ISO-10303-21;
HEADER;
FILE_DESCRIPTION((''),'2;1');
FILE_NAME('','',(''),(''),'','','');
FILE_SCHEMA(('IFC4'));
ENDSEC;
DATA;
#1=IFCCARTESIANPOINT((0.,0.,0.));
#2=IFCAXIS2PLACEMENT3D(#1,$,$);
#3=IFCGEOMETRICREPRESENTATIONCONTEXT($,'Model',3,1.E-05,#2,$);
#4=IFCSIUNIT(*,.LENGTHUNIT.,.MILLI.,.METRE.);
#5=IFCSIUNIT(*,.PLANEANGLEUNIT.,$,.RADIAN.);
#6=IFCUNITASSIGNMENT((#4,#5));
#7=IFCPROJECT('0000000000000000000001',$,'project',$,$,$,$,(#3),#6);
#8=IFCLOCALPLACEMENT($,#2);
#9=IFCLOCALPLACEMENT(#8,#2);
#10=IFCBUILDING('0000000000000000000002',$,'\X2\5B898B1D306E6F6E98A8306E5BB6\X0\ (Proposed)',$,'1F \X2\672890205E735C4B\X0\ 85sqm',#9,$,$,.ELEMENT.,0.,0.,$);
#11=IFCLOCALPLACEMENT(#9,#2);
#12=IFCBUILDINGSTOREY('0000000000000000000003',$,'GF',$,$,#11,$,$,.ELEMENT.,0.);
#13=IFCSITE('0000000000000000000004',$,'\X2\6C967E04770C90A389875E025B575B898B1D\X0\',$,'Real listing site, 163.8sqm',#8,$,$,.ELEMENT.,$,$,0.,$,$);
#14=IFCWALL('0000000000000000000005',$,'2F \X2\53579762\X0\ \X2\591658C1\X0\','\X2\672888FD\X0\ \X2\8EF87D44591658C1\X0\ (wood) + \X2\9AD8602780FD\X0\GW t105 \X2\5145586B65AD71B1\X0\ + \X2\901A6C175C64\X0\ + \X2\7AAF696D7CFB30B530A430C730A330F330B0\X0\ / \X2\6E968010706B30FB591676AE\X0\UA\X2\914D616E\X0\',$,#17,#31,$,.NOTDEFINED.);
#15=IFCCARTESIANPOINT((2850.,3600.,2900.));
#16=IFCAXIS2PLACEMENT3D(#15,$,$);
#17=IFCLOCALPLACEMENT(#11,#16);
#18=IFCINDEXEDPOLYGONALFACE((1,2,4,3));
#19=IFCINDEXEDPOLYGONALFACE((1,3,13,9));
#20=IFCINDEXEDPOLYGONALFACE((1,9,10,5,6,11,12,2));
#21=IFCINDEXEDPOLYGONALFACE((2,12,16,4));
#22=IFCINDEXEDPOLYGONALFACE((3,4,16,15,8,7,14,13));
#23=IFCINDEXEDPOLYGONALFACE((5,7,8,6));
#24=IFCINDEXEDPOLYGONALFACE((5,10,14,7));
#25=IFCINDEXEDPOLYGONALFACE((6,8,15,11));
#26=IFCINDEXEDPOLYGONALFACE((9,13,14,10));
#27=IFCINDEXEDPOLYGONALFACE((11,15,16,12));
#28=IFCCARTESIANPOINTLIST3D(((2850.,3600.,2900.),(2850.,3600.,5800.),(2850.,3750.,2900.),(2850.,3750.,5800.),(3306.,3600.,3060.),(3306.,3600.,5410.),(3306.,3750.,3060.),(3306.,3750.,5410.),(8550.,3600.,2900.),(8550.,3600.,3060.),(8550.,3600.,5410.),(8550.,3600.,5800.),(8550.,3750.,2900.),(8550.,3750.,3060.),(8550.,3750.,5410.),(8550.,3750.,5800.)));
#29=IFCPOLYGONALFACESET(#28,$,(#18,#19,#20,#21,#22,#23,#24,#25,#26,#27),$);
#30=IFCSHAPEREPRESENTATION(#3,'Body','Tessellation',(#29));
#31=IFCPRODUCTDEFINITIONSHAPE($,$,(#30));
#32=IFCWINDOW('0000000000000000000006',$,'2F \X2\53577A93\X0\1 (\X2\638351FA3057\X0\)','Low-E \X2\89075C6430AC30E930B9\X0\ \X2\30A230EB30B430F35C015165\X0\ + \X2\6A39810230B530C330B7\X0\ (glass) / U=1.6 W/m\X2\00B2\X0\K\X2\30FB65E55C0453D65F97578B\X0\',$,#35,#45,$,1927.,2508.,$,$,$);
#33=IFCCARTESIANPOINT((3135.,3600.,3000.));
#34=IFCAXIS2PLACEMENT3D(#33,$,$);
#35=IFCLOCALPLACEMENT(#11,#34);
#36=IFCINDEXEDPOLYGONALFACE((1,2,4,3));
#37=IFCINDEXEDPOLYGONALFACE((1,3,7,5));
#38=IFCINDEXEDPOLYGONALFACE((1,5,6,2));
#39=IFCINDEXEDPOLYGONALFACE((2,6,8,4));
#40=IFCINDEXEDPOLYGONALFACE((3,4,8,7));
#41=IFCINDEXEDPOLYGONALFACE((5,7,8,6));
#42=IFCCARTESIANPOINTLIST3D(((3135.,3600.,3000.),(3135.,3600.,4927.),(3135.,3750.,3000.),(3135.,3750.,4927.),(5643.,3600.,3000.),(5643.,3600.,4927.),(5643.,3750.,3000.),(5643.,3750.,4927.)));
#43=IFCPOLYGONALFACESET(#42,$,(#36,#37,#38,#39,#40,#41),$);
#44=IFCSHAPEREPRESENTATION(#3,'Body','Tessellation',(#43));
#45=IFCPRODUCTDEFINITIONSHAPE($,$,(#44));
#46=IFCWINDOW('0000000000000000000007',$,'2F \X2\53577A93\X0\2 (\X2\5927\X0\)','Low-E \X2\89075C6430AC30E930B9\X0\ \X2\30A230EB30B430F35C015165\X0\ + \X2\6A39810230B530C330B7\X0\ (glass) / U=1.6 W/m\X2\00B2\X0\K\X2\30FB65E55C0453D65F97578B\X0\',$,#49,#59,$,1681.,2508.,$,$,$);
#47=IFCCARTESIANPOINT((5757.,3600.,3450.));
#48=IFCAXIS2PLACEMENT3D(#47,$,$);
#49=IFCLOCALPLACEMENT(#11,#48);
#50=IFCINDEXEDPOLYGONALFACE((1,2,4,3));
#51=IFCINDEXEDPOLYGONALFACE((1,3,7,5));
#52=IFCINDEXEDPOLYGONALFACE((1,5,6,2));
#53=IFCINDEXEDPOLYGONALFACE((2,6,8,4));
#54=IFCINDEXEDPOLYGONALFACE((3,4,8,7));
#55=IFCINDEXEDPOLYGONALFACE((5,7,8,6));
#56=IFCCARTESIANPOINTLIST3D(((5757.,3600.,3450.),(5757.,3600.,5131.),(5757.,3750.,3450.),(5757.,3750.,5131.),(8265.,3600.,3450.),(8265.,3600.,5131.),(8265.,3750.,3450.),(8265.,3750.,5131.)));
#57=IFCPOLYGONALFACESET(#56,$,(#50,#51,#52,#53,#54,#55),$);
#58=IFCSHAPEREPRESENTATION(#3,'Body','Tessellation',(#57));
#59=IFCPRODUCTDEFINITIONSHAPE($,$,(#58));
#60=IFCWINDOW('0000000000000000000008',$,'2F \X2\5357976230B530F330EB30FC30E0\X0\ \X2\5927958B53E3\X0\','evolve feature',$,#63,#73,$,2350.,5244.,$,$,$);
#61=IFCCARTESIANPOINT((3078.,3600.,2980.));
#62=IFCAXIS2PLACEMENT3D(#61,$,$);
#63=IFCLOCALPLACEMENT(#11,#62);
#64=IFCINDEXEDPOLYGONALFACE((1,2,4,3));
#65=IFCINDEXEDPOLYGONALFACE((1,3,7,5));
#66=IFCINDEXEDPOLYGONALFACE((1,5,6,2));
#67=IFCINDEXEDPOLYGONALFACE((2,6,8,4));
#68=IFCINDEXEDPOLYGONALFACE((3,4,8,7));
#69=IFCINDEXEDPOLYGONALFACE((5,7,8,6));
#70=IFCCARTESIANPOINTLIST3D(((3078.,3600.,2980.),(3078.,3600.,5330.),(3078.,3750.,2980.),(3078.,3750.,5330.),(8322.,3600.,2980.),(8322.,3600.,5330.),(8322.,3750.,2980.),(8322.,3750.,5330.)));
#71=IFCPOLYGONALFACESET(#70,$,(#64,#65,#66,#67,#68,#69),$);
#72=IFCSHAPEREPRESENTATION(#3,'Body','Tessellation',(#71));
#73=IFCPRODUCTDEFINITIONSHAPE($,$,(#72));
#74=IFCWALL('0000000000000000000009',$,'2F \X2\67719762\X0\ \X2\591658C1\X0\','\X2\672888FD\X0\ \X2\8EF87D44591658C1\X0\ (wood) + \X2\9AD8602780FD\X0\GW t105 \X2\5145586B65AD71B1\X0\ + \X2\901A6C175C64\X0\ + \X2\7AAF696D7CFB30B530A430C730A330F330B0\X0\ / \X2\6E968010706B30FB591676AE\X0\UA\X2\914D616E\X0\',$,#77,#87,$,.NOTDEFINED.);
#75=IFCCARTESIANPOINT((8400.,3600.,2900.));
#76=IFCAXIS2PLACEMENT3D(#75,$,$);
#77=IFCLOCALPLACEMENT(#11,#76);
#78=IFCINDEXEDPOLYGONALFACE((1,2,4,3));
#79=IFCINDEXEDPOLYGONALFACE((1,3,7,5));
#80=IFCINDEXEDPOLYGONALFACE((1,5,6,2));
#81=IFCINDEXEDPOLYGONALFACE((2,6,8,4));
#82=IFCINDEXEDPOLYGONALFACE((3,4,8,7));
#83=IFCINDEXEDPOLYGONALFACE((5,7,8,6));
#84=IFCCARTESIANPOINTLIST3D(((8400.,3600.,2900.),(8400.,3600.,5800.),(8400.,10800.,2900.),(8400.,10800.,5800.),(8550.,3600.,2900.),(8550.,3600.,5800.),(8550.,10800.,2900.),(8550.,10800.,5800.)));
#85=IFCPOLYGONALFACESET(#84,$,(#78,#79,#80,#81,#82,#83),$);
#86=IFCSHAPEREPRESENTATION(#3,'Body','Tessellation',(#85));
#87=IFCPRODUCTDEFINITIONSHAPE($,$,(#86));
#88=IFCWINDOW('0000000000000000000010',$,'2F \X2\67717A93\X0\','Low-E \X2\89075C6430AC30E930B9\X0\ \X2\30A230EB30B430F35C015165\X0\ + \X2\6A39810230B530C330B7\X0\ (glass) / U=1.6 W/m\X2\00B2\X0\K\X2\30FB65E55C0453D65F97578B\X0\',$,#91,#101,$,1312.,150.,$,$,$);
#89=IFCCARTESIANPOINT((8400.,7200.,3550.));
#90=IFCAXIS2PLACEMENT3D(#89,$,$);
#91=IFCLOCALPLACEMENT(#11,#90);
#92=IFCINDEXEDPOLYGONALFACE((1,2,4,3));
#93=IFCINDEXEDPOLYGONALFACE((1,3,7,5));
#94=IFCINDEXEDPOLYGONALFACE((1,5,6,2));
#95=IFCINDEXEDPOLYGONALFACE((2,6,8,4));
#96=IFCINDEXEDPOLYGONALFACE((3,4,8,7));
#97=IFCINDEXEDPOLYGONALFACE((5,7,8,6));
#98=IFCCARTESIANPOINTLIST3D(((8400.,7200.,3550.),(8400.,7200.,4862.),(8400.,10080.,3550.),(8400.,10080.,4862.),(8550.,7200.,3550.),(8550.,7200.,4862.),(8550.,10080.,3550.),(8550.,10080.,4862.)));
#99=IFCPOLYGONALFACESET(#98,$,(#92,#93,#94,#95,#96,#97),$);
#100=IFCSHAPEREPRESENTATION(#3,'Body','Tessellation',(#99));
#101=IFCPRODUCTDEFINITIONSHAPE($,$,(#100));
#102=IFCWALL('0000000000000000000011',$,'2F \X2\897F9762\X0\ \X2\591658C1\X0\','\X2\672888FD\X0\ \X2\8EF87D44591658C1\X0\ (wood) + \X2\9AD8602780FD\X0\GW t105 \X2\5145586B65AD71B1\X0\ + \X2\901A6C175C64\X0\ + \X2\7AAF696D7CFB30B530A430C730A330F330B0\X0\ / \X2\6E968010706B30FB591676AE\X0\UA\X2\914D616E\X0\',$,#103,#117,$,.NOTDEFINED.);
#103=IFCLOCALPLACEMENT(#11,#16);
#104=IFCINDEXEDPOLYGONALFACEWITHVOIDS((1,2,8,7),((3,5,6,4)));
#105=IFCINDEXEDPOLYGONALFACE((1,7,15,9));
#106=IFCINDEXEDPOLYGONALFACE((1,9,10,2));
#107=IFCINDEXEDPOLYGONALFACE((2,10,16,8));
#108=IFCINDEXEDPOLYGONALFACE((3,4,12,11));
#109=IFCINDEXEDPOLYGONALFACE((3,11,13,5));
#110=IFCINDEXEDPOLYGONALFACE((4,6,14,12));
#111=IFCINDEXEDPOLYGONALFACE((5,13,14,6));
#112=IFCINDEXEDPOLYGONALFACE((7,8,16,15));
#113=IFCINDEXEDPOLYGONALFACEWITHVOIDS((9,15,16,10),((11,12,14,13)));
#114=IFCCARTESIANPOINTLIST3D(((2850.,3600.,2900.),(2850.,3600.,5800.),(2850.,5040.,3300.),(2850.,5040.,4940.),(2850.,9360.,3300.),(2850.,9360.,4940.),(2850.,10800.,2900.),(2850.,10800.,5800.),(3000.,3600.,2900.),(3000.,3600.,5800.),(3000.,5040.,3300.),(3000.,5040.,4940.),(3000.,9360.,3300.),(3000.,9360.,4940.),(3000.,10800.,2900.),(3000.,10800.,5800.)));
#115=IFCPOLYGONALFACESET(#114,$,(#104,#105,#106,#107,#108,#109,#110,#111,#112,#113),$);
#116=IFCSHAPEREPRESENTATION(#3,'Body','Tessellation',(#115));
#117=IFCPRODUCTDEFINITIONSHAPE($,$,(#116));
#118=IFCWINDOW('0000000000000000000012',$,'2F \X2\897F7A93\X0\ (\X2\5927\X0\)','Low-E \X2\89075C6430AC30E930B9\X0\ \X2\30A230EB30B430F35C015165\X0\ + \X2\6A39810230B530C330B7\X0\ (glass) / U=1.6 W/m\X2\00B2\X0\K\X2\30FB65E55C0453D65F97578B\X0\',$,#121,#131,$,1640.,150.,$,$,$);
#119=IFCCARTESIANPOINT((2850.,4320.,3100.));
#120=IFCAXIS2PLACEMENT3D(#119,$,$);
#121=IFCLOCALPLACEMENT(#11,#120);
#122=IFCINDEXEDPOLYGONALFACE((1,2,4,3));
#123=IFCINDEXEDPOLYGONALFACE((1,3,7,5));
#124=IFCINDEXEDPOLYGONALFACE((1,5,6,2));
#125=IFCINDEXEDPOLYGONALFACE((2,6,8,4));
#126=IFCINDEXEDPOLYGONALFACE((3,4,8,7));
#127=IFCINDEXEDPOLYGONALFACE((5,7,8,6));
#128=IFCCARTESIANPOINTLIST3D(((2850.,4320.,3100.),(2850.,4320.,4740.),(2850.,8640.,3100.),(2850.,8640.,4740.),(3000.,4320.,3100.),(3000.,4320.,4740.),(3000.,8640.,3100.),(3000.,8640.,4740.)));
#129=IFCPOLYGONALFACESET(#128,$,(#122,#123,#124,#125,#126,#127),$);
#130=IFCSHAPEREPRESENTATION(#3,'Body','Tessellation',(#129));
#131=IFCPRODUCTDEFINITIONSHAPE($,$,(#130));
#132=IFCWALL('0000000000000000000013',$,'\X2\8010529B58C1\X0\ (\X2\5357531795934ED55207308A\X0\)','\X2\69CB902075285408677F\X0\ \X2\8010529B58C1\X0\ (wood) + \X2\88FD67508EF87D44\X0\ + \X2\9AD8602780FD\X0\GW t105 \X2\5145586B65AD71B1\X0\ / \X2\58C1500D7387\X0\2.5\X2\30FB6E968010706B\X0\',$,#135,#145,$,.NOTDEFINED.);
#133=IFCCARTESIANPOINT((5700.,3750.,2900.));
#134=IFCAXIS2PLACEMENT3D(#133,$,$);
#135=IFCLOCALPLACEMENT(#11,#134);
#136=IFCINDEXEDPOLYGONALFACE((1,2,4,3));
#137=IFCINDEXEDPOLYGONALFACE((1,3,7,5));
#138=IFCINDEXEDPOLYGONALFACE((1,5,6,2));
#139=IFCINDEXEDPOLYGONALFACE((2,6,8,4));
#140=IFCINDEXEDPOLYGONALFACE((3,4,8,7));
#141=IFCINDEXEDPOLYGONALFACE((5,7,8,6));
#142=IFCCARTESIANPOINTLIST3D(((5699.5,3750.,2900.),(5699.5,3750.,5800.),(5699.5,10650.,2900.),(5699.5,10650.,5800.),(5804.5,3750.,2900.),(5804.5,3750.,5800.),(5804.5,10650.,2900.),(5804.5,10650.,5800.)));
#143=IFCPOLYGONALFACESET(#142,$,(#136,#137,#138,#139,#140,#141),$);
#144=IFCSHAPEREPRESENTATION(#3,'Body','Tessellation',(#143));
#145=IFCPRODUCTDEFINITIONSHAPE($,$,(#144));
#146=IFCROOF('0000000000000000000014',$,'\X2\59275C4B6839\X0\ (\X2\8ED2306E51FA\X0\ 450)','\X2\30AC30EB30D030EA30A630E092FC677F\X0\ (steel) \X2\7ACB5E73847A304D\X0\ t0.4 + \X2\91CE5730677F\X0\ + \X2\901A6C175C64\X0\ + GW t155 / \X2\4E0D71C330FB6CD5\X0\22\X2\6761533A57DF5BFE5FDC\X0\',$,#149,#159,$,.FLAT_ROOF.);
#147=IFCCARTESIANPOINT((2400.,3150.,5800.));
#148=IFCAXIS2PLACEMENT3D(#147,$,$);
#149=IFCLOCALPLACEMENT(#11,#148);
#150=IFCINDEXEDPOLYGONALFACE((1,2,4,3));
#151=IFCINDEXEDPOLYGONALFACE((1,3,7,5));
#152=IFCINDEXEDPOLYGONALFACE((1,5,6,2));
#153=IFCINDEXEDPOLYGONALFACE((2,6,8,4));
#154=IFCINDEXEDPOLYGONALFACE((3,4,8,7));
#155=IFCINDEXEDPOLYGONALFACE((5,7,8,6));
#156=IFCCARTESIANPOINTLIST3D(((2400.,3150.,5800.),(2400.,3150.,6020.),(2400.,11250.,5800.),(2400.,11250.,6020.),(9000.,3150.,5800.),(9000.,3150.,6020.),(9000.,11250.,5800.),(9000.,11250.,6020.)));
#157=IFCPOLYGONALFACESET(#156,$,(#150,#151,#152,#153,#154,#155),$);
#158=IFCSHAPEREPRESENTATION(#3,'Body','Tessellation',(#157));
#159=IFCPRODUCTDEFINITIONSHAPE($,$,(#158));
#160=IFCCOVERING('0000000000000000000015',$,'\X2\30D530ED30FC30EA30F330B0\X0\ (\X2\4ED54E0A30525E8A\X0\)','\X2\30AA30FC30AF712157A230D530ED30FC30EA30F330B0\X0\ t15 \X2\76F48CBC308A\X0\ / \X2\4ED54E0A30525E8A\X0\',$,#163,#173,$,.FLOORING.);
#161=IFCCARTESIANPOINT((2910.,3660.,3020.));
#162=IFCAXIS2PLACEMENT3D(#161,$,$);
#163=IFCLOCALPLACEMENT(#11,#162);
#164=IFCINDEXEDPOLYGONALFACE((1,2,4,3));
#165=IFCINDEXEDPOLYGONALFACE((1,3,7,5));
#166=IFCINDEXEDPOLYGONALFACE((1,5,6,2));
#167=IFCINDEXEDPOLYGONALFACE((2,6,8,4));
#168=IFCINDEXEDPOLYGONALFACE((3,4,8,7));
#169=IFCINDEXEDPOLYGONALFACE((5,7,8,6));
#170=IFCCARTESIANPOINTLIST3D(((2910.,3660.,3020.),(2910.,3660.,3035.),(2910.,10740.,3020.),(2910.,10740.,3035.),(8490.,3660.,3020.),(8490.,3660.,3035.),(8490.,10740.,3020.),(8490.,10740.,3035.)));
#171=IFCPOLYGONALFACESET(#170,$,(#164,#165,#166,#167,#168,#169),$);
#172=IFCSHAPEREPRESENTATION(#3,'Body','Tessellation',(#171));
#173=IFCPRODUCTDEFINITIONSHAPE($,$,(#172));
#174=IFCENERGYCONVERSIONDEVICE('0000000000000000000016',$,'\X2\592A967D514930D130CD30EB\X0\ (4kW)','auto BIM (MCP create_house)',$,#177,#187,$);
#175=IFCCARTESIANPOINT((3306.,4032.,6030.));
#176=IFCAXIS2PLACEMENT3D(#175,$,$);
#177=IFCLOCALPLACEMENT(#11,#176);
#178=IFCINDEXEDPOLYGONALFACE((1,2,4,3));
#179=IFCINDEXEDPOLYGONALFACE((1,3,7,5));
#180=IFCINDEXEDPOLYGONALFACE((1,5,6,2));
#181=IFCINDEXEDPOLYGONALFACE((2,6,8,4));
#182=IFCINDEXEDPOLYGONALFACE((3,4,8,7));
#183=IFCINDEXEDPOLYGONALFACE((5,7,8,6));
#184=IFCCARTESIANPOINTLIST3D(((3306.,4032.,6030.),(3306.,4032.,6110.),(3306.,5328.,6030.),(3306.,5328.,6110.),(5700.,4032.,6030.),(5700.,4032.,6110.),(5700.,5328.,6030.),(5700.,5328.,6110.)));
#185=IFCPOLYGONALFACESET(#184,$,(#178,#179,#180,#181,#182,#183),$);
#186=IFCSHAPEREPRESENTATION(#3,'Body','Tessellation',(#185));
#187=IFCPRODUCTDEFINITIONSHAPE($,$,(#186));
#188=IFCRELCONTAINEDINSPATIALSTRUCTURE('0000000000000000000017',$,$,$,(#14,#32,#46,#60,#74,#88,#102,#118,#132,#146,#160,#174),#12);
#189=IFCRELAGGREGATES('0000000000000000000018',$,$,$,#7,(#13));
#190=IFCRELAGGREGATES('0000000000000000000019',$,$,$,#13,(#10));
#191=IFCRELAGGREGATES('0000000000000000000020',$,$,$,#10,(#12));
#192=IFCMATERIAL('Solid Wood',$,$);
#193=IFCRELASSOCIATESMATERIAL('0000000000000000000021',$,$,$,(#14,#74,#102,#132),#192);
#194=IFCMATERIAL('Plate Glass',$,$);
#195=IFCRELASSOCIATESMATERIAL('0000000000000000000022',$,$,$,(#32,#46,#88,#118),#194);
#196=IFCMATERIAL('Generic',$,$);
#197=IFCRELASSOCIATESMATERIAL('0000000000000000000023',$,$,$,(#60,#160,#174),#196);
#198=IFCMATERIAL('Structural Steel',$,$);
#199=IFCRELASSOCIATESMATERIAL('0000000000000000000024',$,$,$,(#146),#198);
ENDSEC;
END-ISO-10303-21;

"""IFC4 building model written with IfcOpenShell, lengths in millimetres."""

from ifc_helpers import new_model, si_unit, frame, frame_2d, origin, place, context, project, spatial, rectangle, extrude, material, element, fill, save


model = new_model("IFC4")

# Units and contexts
model_context = context("Model", 3, precision=1e-05, world=origin())
ifc_project = project(units=[si_unit("LENGTHUNIT", "METRE", prefix="MILLI"), si_unit("PLANEANGLEUNIT", "RADIAN")], contexts=[model_context])

# Site, building, storey
site_placement = place(None, origin())
site = spatial("IfcSite", under=ifc_project, at=site_placement, Name="沖縄県那覇市字安謝", ObjectType="Real listing site, 163.8sqm", CompositionType="ELEMENT", RefElevation=0.0)
building_placement = place(site_placement, origin())
building = spatial("IfcBuilding", under=site, at=building_placement, Name="安謝の潮風の家 (Proposed)", ObjectType="1F 木造平屋 85sqm", CompositionType="ELEMENT", ElevationOfRefHeight=0.0, ElevationOfTerrain=0.0)
storey_placement = place(building_placement, origin())
storey = spatial("IfcBuildingStorey", under=building, at=storey_placement, Name="GF", CompositionType="ELEMENT", Elevation=0.0)

# Shared definitions
ifc_material_1 = material(Name="Solid Wood")

# Wall, openings, windows
wall_1_placement = place(storey_placement, frame((2850.0, 3600.0, 2900.0)))
wall_1 = element("IfcWall", 1, at=wall_1_placement, inside=storey, material=ifc_material_1, Name="2F 南面 外壁", Description="木製 軸組外壁 (wood) + 高性能GW t105 充填断熱 + 通気層 + 窯業系サイディング / 準耐火・外皮UA配慮", PredefinedType="NOTDEFINED", context=model_context, shape_type="SweptSolid", body=[
    extrude(rectangle(XDim=5700.0, YDim=150.0, at=frame_2d((2850.0, 75.0))), frame((2850.0, 3600.0, 2900.0)), (0.0, 0.0, 1.0), 2900.0),
])
opening_1_placement = place(storey_placement, frame((3135.0, 3600.0, 3000.0)))
opening_1 = element("IfcOpeningElement", 2, at=opening_1_placement, cuts=wall_1, PredefinedType="NOTDEFINED", context=model_context, shape_type="SweptSolid", body=[
    extrude(rectangle(XDim=2508.0, YDim=150.0, at=frame_2d((1254.0, 75.0))), frame((3135.0, 3600.0, 3000.0)), (0.0, 0.0, 1.0), 1927.0),
])
opening_2_placement = place(storey_placement, frame((5757.0, 3600.0, 3450.0)))
opening_2 = element("IfcOpeningElement", 3, at=opening_2_placement, cuts=wall_1, PredefinedType="NOTDEFINED", context=model_context, shape_type="SweptSolid", body=[
    extrude(rectangle(XDim=2508.0, YDim=150.0, at=frame_2d((1254.0, 75.0))), frame((5757.0, 3600.0, 3450.0)), (0.0, 0.0, 1.0), 1681.0),
])
opening_3_placement = place(storey_placement, frame((3078.0, 3600.0, 2980.0)))
opening_3 = element("IfcOpeningElement", 4, at=opening_3_placement, cuts=wall_1, PredefinedType="NOTDEFINED", context=model_context, shape_type="SweptSolid", body=[
    extrude(rectangle(XDim=5244.0, YDim=150.0, at=frame_2d((2622.0, 75.0))), frame((3078.0, 3600.0, 2980.0)), (0.0, 0.0, 1.0), 2350.0),
])
ifc_material_2 = material(Name="Plate Glass")
window_1_placement = place(storey_placement, frame((3135.0, 3600.0, 3000.0)))
window_1 = element("IfcWindow", 5, at=window_1_placement, inside=storey, material=ifc_material_2, Name="2F 南窓1 (掃出し)", Description="Low-E 複層ガラス アルゴン封入 + 樹脂サッシ (glass) / U=1.6 W/m²K・日射取得型", OverallHeight=1927.0, OverallWidth=2508.0, context=model_context, shape_type="SweptSolid", body=[
    extrude(rectangle(XDim=2508.0, YDim=150.0, at=frame_2d((1254.0, 75.0))), frame((3135.0, 3600.0, 3000.0)), (0.0, 0.0, 1.0), 1927.0),
])
fill(opening_1, window_1)
window_2_placement = place(storey_placement, frame((5757.0, 3600.0, 3450.0)))
window_2 = element("IfcWindow", 6, at=window_2_placement, inside=storey, material=ifc_material_2, Name="2F 南窓2 (大)", Description="Low-E 複層ガラス アルゴン封入 + 樹脂サッシ (glass) / U=1.6 W/m²K・日射取得型", OverallHeight=1681.0, OverallWidth=2508.0, context=model_context, shape_type="SweptSolid", body=[
    extrude(rectangle(XDim=2508.0, YDim=150.0, at=frame_2d((1254.0, 75.0))), frame((5757.0, 3600.0, 3450.0)), (0.0, 0.0, 1.0), 1681.0),
])
fill(opening_2, window_2)
ifc_material_3 = material(Name="Generic")
window_3_placement = place(storey_placement, frame((3078.0, 3600.0, 2980.0)))
window_3 = element("IfcWindow", 7, at=window_3_placement, inside=storey, material=ifc_material_3, Name="2F 南面サンルーム 大開口", Description="evolve feature", OverallHeight=2350.0, OverallWidth=5244.0, context=model_context, shape_type="SweptSolid", body=[
    extrude(rectangle(XDim=5244.0, YDim=150.0, at=frame_2d((2622.0, 75.0))), frame((3078.0, 3600.0, 2980.0)), (0.0, 0.0, 1.0), 2350.0),
])
fill(opening_3, window_3)

# Walls, openings, windows
wall_2_placement = place(storey_placement, frame((8400.0, 3600.0, 2900.0)))
wall_2 = element("IfcWall", 8, at=wall_2_placement, inside=storey, material=ifc_material_1, Name="2F 東面 外壁", Description="木製 軸組外壁 (wood) + 高性能GW t105 充填断熱 + 通気層 + 窯業系サイディング / 準耐火・外皮UA配慮", PredefinedType="NOTDEFINED", context=model_context, shape_type="SweptSolid", body=[
    extrude(rectangle(XDim=150.0, YDim=7200.0, at=frame_2d((75.0, 3600.0))), frame((8400.0, 3600.0, 2900.0)), (0.0, 0.0, 1.0), 2900.0),
])
opening_4_placement = place(storey_placement, frame((8400.0, 7200.0, 3550.0)))
opening_4 = element("IfcOpeningElement", 9, at=opening_4_placement, cuts=wall_2, PredefinedType="NOTDEFINED", context=model_context, shape_type="SweptSolid", body=[
    extrude(rectangle(XDim=150.0, YDim=2880.0, at=frame_2d((75.0, 1440.0))), frame((8400.0, 7200.0, 3550.0)), (0.0, 0.0, 1.0), 1312.0),
])
window_4_placement = place(storey_placement, frame((8400.0, 7200.0, 3550.0)))
window_4 = element("IfcWindow", 10, at=window_4_placement, inside=storey, material=ifc_material_2, Name="2F 東窓", Description="Low-E 複層ガラス アルゴン封入 + 樹脂サッシ (glass) / U=1.6 W/m²K・日射取得型", OverallHeight=1312.0, OverallWidth=150.0, context=model_context, shape_type="SweptSolid", body=[
    extrude(rectangle(XDim=150.0, YDim=2880.0, at=frame_2d((75.0, 1440.0))), frame((8400.0, 7200.0, 3550.0)), (0.0, 0.0, 1.0), 1312.0),
])
fill(opening_4, window_4)
wall_3_placement = place(storey_placement, frame((2850.0, 3600.0, 2900.0)))
wall_3 = element("IfcWall", 11, at=wall_3_placement, inside=storey, material=ifc_material_1, Name="2F 西面 外壁", Description="木製 軸組外壁 (wood) + 高性能GW t105 充填断熱 + 通気層 + 窯業系サイディング / 準耐火・外皮UA配慮", PredefinedType="NOTDEFINED", context=model_context, shape_type="SweptSolid", body=[
    extrude(rectangle(XDim=150.0, YDim=7200.0, at=frame_2d((75.0, 3600.0))), frame((2850.0, 3600.0, 2900.0)), (0.0, 0.0, 1.0), 2900.0),
])
opening_5_placement = place(storey_placement, frame((2850.0, 4320.0, 3100.0)))
opening_5 = element("IfcOpeningElement", 12, at=opening_5_placement, cuts=wall_3, PredefinedType="NOTDEFINED", context=model_context, shape_type="SweptSolid", body=[
    extrude(rectangle(XDim=150.0, YDim=4320.0, at=frame_2d((75.0, 2160.0))), frame((2850.0, 4320.0, 3100.0)), (0.0, 0.0, 1.0), 1640.0),
])
window_5_placement = place(storey_placement, frame((2850.0, 4320.0, 3100.0)))
window_5 = element("IfcWindow", 13, at=window_5_placement, inside=storey, material=ifc_material_2, Name="2F 西窓 (大)", Description="Low-E 複層ガラス アルゴン封入 + 樹脂サッシ (glass) / U=1.6 W/m²K・日射取得型", OverallHeight=1640.0, OverallWidth=150.0, context=model_context, shape_type="SweptSolid", body=[
    extrude(rectangle(XDim=150.0, YDim=4320.0, at=frame_2d((75.0, 2160.0))), frame((2850.0, 4320.0, 3100.0)), (0.0, 0.0, 1.0), 1640.0),
])
fill(opening_5, window_5)

# Wall
wall_4_placement = place(storey_placement, frame((5700.0, 3750.0, 2900.0)))
element("IfcWall", 14, at=wall_4_placement, inside=storey, material=ifc_material_1, Name="耐力壁 (南北間仕切り)", Description="構造用合板 耐力壁 (wood) + 製材軸組 + 高性能GW t105 充填断熱 / 壁倍率2.5・準耐火", PredefinedType="NOTDEFINED", context=model_context, shape_type="SweptSolid", body=[
    extrude(rectangle(XDim=105.0, YDim=6900.0, at=frame_2d((52.0, 3450.0))), frame((5700.0, 3750.0, 2900.0)), (0.0, 0.0, 1.0), 2900.0),
])

# Roof
ifc_material_4 = material(Name="Structural Steel")
roof_placement = place(storey_placement, frame((2400.0, 3150.0, 5800.0)))
element("IfcRoof", 15, at=roof_placement, inside=storey, material=ifc_material_4, Name="大屋根 (軒の出 450)", Description="ガルバリウム鋼板 (steel) 立平葺き t0.4 + 野地板 + 通気層 + GW t155 / 不燃・法22条区域対応", PredefinedType="FLAT_ROOF", context=model_context, shape_type="SweptSolid", body=[
    extrude(rectangle(XDim=6600.0, YDim=8100.0, at=frame_2d((3300.0, 4050.0))), frame((2400.0, 3150.0, 5800.0)), (0.0, 0.0, 1.0), 220.0),
])

# Covering
covering_placement = place(storey_placement, frame((2910.0, 3660.0, 3020.0)))
element("IfcCovering", 16, at=covering_placement, inside=storey, material=ifc_material_3, Name="フローリング (仕上げ床)", Description="オーク無垢フローリング t15 直貼り / 仕上げ床", PredefinedType="FLOORING", context=model_context, shape_type="SweptSolid", body=[
    extrude(rectangle(XDim=5580.0, YDim=7080.0, at=frame_2d((2790.0, 3540.0))), frame((2910.0, 3660.0, 3020.0)), (0.0, 0.0, 1.0), 15.0),
])

# Energy conversion device
energy_conversion_device_placement = place(storey_placement, frame((3306.0, 4032.0, 6030.0)))
element("IfcEnergyConversionDevice", 17, at=energy_conversion_device_placement, inside=storey, material=ifc_material_3, Name="太陽光パネル (4kW)", Description="auto BIM (MCP create_house)", context=model_context, shape_type="SweptSolid", body=[
    extrude(rectangle(XDim=2394.0, YDim=1296.0, at=frame_2d((1197.0, 648.0))), frame((3306.0, 4032.0, 6030.0)), (0.0, 0.0, 1.0), 80.0),
])

save(model, "model.ifc")
